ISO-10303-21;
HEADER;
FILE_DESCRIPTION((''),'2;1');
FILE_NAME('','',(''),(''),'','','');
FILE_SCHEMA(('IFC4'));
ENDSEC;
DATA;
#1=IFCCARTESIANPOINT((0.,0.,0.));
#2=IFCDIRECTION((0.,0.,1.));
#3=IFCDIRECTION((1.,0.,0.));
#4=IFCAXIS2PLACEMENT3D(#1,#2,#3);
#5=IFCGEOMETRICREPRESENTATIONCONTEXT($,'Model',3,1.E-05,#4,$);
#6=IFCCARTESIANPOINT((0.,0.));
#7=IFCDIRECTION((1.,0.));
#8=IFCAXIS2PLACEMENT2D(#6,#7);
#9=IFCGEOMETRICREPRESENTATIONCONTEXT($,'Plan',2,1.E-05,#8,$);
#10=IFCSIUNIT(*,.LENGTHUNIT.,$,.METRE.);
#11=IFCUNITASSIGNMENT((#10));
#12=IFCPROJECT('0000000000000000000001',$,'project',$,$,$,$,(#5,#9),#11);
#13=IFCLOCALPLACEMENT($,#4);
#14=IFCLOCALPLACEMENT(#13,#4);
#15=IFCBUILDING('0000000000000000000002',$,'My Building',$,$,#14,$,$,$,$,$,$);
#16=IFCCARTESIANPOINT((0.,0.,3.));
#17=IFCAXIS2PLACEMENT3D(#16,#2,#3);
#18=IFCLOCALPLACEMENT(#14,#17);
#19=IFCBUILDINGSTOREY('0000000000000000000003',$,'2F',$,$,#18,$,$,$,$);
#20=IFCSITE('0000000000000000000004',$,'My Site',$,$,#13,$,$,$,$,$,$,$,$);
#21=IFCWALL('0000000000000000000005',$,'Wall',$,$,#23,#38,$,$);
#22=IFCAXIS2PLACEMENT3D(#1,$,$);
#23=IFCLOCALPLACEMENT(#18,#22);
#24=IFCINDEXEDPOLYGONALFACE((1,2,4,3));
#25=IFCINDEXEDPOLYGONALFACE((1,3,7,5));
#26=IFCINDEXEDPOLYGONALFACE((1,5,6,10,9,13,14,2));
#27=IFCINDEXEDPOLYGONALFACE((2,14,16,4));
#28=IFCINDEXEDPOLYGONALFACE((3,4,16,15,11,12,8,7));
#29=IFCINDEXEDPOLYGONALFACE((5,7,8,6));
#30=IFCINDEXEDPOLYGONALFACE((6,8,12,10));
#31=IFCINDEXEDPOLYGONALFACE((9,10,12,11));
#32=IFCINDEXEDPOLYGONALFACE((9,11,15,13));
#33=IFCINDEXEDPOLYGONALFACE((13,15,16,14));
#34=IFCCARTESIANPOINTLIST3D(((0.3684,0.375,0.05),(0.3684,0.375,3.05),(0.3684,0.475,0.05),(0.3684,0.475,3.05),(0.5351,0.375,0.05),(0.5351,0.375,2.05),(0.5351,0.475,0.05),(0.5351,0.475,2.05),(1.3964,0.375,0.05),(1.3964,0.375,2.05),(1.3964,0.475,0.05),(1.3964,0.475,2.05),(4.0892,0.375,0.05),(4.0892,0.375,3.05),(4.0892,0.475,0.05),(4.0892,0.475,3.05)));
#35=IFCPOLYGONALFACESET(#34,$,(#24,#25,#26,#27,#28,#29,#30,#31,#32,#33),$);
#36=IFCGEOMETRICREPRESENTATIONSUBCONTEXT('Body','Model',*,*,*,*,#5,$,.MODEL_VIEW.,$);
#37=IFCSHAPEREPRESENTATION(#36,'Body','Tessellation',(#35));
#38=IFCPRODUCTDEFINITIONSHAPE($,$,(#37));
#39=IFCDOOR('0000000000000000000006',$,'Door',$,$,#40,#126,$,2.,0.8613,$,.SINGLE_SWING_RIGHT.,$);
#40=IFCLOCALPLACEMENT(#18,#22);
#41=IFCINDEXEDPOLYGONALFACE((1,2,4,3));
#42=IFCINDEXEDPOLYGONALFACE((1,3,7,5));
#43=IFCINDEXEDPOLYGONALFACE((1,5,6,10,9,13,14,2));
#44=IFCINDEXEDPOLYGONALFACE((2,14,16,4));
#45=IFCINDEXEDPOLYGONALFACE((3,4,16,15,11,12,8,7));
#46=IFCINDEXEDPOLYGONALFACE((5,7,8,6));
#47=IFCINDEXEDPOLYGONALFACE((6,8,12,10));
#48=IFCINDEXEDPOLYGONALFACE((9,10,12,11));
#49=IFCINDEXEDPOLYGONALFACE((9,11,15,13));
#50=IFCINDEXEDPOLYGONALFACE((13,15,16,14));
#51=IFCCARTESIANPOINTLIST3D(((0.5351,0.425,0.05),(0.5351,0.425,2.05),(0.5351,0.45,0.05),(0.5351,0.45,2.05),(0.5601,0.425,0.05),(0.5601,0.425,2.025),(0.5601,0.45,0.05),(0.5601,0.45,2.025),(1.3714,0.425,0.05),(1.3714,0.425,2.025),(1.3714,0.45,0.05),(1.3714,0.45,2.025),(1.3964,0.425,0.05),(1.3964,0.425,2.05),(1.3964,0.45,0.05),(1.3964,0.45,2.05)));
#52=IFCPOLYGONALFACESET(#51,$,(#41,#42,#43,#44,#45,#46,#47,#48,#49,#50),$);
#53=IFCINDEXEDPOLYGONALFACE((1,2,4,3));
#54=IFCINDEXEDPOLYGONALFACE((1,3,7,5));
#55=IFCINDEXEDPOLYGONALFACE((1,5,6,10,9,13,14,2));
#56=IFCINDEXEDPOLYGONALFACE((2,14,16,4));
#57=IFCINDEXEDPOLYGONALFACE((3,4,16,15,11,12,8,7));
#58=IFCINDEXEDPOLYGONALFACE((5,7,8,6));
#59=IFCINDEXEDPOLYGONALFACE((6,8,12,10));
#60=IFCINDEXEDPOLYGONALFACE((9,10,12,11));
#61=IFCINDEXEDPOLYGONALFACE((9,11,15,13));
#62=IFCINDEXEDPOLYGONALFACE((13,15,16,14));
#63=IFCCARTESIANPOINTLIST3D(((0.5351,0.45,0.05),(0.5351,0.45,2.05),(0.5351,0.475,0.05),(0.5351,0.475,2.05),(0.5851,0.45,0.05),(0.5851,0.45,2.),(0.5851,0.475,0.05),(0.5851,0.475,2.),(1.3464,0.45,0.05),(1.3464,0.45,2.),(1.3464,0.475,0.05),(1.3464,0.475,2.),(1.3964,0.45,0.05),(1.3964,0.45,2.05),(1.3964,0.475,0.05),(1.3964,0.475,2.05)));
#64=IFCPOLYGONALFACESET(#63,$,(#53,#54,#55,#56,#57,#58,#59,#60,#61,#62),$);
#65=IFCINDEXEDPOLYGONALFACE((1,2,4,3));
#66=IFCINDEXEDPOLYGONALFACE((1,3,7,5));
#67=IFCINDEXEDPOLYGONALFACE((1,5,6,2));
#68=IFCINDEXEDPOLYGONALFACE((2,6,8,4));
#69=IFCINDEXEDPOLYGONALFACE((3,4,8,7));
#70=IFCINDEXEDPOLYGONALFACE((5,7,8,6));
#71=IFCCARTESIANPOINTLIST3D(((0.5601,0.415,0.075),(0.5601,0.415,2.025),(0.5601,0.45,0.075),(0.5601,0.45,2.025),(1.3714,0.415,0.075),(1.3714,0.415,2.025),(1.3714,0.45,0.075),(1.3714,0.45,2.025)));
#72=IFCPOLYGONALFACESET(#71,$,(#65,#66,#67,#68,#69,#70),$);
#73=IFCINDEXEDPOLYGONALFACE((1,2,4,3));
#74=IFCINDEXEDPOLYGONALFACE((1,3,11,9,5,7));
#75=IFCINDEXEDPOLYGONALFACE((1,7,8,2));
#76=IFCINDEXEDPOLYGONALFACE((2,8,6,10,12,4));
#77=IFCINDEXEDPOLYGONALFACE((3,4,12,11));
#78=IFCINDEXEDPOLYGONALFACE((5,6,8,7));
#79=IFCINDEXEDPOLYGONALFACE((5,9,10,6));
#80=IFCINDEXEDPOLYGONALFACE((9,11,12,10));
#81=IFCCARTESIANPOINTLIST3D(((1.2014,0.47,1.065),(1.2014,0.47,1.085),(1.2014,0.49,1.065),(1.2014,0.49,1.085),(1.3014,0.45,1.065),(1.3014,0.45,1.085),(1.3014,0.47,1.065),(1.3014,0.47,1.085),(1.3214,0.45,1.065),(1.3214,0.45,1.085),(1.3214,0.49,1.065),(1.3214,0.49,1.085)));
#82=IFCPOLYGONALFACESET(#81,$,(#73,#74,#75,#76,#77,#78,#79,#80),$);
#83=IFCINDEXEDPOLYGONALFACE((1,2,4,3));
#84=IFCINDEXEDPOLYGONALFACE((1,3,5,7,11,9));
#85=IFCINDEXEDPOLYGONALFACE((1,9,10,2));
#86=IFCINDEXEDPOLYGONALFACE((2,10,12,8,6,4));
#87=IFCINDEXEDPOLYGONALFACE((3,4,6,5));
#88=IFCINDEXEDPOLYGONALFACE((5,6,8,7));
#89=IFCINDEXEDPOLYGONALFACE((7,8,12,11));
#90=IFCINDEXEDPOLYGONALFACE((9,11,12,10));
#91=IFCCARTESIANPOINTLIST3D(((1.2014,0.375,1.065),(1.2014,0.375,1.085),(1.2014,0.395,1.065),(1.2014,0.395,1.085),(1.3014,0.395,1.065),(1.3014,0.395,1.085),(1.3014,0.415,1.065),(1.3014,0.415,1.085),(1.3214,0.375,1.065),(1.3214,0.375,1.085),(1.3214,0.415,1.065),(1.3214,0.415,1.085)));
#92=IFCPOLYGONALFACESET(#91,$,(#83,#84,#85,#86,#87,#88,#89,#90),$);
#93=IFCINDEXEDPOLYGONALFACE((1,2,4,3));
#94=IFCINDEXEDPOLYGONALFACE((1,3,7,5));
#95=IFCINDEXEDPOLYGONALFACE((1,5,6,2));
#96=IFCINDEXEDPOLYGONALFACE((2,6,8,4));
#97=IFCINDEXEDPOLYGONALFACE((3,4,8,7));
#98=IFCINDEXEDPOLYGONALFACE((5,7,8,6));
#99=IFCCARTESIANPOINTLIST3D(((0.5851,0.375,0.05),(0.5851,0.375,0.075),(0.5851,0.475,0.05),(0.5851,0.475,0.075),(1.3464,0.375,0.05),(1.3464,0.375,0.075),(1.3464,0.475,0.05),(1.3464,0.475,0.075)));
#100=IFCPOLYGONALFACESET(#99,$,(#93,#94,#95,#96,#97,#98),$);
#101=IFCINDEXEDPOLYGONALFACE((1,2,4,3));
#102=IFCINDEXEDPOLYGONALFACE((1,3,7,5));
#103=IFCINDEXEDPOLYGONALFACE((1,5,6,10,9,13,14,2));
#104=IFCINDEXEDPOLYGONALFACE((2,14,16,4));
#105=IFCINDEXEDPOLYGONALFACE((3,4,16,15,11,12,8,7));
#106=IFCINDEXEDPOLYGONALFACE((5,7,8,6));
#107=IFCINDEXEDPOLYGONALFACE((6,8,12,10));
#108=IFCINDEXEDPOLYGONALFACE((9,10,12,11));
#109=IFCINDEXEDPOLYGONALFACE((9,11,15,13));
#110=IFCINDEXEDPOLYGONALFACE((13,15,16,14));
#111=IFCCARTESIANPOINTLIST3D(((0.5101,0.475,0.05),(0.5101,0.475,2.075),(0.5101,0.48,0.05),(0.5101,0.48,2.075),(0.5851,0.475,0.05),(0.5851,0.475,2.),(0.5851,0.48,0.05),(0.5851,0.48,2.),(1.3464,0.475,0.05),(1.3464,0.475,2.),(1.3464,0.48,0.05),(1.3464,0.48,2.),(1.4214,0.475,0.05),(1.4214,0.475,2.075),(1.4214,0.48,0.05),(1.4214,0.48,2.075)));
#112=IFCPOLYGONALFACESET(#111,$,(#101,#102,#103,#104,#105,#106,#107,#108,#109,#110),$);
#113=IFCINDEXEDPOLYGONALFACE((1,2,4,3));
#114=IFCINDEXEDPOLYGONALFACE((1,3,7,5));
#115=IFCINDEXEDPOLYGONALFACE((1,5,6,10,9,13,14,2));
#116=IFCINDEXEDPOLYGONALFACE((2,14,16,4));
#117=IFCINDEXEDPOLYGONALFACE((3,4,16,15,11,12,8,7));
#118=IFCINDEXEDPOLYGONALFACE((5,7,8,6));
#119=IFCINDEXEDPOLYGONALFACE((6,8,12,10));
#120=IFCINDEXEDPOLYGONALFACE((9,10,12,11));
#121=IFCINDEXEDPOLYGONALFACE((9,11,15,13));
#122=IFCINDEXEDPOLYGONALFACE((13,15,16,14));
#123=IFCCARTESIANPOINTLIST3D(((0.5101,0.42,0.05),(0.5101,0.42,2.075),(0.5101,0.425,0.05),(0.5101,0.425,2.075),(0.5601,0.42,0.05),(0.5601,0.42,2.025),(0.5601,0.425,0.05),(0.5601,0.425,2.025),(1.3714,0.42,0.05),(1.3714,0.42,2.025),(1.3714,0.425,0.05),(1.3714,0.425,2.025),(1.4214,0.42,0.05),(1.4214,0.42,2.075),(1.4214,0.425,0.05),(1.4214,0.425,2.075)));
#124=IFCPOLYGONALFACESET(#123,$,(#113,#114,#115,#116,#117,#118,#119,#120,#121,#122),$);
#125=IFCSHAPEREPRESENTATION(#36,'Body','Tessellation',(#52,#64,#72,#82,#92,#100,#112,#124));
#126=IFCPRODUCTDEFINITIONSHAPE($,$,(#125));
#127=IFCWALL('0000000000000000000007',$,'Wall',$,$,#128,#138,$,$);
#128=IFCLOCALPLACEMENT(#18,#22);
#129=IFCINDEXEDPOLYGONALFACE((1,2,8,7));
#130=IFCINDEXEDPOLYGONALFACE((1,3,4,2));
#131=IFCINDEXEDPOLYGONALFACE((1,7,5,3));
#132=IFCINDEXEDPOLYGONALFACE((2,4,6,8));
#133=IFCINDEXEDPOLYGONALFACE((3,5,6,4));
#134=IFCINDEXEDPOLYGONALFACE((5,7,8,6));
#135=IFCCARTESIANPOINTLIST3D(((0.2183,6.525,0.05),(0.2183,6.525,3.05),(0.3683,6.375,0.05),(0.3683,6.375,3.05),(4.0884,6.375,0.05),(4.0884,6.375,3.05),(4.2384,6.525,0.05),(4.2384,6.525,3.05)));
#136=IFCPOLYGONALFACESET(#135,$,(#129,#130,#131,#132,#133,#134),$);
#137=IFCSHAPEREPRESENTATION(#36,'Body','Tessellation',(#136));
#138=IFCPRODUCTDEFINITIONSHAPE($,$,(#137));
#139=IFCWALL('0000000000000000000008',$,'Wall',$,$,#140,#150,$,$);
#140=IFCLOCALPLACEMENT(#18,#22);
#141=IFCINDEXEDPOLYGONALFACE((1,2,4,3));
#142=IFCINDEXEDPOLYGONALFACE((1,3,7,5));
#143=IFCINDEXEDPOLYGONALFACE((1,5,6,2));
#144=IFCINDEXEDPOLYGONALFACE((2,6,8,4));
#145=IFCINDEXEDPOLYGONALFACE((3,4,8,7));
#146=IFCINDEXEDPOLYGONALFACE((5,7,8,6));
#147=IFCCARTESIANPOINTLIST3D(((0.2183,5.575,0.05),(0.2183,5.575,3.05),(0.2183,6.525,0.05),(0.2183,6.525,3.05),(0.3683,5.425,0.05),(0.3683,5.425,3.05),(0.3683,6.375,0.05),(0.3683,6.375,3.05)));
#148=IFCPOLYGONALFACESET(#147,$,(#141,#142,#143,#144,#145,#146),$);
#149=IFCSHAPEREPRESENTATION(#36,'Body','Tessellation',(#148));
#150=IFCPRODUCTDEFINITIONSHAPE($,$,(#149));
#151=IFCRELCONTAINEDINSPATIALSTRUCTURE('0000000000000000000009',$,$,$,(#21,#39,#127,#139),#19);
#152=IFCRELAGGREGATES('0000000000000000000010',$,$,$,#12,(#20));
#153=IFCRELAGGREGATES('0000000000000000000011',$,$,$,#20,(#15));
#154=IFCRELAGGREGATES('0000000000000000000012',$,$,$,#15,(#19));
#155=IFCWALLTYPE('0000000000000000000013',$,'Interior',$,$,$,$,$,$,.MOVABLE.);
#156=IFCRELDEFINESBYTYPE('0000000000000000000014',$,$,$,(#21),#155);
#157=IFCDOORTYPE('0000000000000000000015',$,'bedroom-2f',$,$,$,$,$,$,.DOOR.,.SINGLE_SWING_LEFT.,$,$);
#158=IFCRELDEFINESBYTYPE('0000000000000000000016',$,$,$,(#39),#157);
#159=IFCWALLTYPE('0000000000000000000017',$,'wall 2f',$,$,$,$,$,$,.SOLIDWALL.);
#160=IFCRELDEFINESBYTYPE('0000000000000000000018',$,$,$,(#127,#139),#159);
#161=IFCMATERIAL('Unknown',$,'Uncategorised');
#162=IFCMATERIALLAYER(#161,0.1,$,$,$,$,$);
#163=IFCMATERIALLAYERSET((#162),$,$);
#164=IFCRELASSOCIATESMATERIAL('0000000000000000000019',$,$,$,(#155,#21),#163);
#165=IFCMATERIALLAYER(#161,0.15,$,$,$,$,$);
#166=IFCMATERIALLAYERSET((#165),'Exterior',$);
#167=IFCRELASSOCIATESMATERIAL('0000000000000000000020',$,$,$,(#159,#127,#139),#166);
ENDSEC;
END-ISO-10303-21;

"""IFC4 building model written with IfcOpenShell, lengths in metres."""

from ifc_helpers import new_model, entity, si_unit, frame, origin_with_axes, origin_2d_with_axis, place, context, subcontext, project, spatial, line, indexed_curve, outline, extrude, shape, source, transform, mapped, material, layer, layer_set, layer_usage, type_object, type_shapes, element, fill, save


model = new_model("IFC4")

# Units and contexts
model_context = context("Model", 3, precision=1e-05, world=origin_with_axes())
plan_context = context("Plan", 2, precision=1e-05, world=origin_2d_with_axis())
body_context_1 = subcontext(model_context, "Body", "Model", "MODEL_VIEW")
body_context_2 = subcontext(plan_context, "Body", "Plan", "PLAN_VIEW")
ifc_project = project(units=[si_unit("LENGTHUNIT", "METRE")], contexts=[model_context, plan_context])

# Site, building, storey
site_placement = place(None, origin_with_axes())
site = spatial("IfcSite", under=ifc_project, at=site_placement, Name="My Site")
building_placement = place(site_placement, origin_with_axes())
building = spatial("IfcBuilding", under=site, at=building_placement, Name="My Building")
storey_placement = place(building_placement, frame((0.0, 0.0, 3.0), z_axis=(0.0, 0.0, 1.0), x_axis=(1.0, 0.0, 0.0)))
storey = spatial("IfcBuildingStorey", under=building, at=storey_placement, Name="2F")

# Shared definitions
ifc_material = material(Name="Unknown", Category="Uncategorised")

# Shared definitions
ifc_layer_1 = layer(ifc_material, 0.1)
ifc_layer_set_1 = layer_set([ifc_layer_1])
wall_type_1 = type_object("IfcWallType", Name="Interior", PredefinedType="MOVABLE", material=ifc_layer_set_1)
shared_shape_1 = source(origin_with_axes(), body_context_1, "Body", "SweptSolid", [
    extrude(outline(indexed_curve([(0.0, 0.0), (0.8613, 0.0), (0.8613, 2.0), (0.0, 2.0)], segments=[line(1, 2, 3, 4, 1)])), frame((0.0, -0.6, 0.0), z_axis=(0.0, -1.0, 0.0), x_axis=(1.0, 0.0, 0.0)), (0.0, 0.0, -1.0), 1.2),
])
door_type_1 = type_object("IfcDoorType", Name="bedroom-2f", OperationType="SINGLE_SWING_LEFT", PredefinedType="DOOR")
shared_shape_2 = source(origin_with_axes(), body_context_1, "Body", "SweptSolid", [
    extrude(outline(indexed_curve([(0.0, 0.0), (0.0, 2.0), (0.8613, 2.0), (0.8613, 0.0), (0.8363, 0.0), (0.8363, 1.975), (0.025, 1.975), (0.025, 0.0)], segments=[line(1, 2, 3, 4, 5, 6, 7, 8, 1)])), frame((0.0, 0.025, 0.0), z_axis=(0.0, -1.0, 0.0), x_axis=(1.0, 0.0, 0.0)), (0.0, 0.0, -1.0), 0.025),
    extrude(outline(indexed_curve([(0.0, 0.0), (0.0, 2.0), (0.8613, 2.0), (0.8613, 0.0), (0.8113, 0.0), (0.8113, 1.95), (0.05, 1.95), (0.05, 0.0)], segments=[line(1, 2, 3, 4, 5, 6, 7, 8, 1)])), frame((0.0, 0.0, 0.0), z_axis=(0.0, -1.0, 0.0), x_axis=(1.0, 0.0, 0.0)), (0.0, 0.0, -1.0), 0.025),
    extrude(outline(indexed_curve([(0.0, 0.0), (0.8113, 0.0), (0.8113, 0.035), (0.0, 0.035)], segments=[line(1, 2, 3, 4, 1)])), frame((0.025, 0.025, 0.025), z_axis=(0.0, 0.0, 1.0), x_axis=(1.0, 0.0, 0.0)), (0.0, 0.0, 1.0), 1.95),
    extrude(outline(indexed_curve([(0.0, 0.0), (0.0, -0.04), (0.12, -0.04), (0.12, -0.02), (0.02, -0.02), (0.02, 0.0)], segments=[line(1, 2, 3, 4, 5, 6, 1)])), frame((0.075, 0.025, 1.015), z_axis=(0.0, 0.0, 1.0), x_axis=(1.0, 0.0, 0.0)), (0.0, 0.0, 1.0), 0.02),
    extrude(outline(indexed_curve([(0.0, 0.0), (0.0, 0.04), (0.12, 0.04), (0.12, 0.02), (0.02, 0.02), (0.02, 0.0)], segments=[line(1, 2, 3, 4, 5, 6, 1)])), frame((0.075, 0.06, 1.015), z_axis=(0.0, 0.0, 1.0), x_axis=(1.0, 0.0, 0.0)), (0.0, 0.0, 1.0), 0.02),
    extrude(outline(indexed_curve([(0.0, 0.0), (0.7613, 0.0), (0.7613, 0.1), (0.0, 0.1)], segments=[line(1, 2, 3, 4, 1)])), frame((0.05, 0.0, 0.0), z_axis=(0.0, 0.0, 1.0), x_axis=(1.0, 0.0, 0.0)), (0.0, 0.0, 1.0), 0.025),
    extrude(outline(indexed_curve([(0.0, 0.0), (0.0, 2.025), (0.9113, 2.025), (0.9113, 0.0), (0.8363, 0.0), (0.8363, 1.95), (0.075, 1.95), (0.075, 0.0)], segments=[line(1, 2, 3, 4, 5, 6, 7, 8, 1)])), frame((-0.025, -0.005, 0.0), z_axis=(0.0, -1.0, 0.0), x_axis=(1.0, 0.0, 0.0)), (0.0, 0.0, -1.0), 0.005),
    extrude(outline(indexed_curve([(0.0, 0.0), (0.0, 2.025), (0.9113, 2.025), (0.9113, 0.0), (0.8613, 0.0), (0.8613, 1.975), (0.05, 1.975), (0.05, 0.0)], segments=[line(1, 2, 3, 4, 5, 6, 7, 8, 1)])), frame((-0.025, 0.05, 0.0), z_axis=(0.0, -1.0, 0.0), x_axis=(1.0, 0.0, 0.0)), (0.0, 0.0, -1.0), 0.005),
])
shared_shape_3 = source(origin_with_axes(), body_context_2, "Body", "Curve2D", [
    entity("IfcIndexedPolyCurve", entity("IfcCartesianPointList2D", [[0.0, 0.0], [0.0, 0.05], [0.025, 0.05], [0.025, 0.025], [0.05, 0.025], [0.05, 0.0]]), [entity("IfcLineIndex", [1, 2, 3, 4, 5, 6, 1])]),
    entity("IfcIndexedPolyCurve", entity("IfcCartesianPointList2D", [[0.8613, 0.0], [0.8613, 0.05], [0.8363, 0.05], [0.8363, 0.025], [0.8113, 0.025], [0.8113, 0.0]]), [entity("IfcLineIndex", [1, 2, 3, 4, 5, 6, 1])]),
    entity("IfcTrimmedCurve", entity("IfcEllipse", entity("IfcAxis2Placement2D", entity("IfcCartesianPoint", [0.8013, 0.05]), entity("IfcDirection", [1.0, 0.0])), 0.7763, 0.8113), [entity("IfcCartesianPoint", [0.8013, 0.8613])], [entity("IfcCartesianPoint", [0.025, 0.05])], True, "CARTESIAN"),
    entity("IfcIndexedPolyCurve", entity("IfcCartesianPointList2D", [[0.8363, 0.05], [0.8013, 0.05], [0.8013, 0.8613], [0.8363, 0.8613]]), [entity("IfcLineIndex", [1, 2, 3, 4, 1])]),
])
type_shapes(door_type_1, [shared_shape_2, shared_shape_3])

# Wall, opening, door
ifc_layer_usage_1 = layer_usage(ifc_layer_set_1, "AXIS2", "POSITIVE", 0.0)
wall_1_placement = place(storey_placement, frame((0.3684, 0.375, 0.05), z_axis=(0.0, 0.0, 1.0), x_axis=(1.0, 0.0, 0.0)))
wall_1 = element("IfcWall", 1, at=wall_1_placement, inside=storey, type_object=wall_type_1, material=ifc_layer_usage_1, Name="Wall", context=body_context_1, shape_type="SweptSolid", body=[
    extrude(outline(indexed_curve([(0.0, 0.0), (0.0, 0.1), (3.7209, 0.1), (3.7209, 0.0)], segments=[line(1, 2, 3, 4, 1)])), origin_with_axes(), (0.0, 0.0, 1.0), 3.0),
])
opening_1_placement = place(wall_1_placement, frame((1.028, 0.1, 0.0), z_axis=(0.0, 0.0, 1.0), x_axis=(-1.0, 0.0, 0.0)))
opening_1 = element("IfcOpeningElement", 2, at=opening_1_placement, cuts=wall_1, PredefinedType="OPENING", context=body_context_1, shape_type="MappedRepresentation", body=[
    mapped(shared_shape_1, transform((0.0, 0.0, 0.0), x_axis=(1.0, 0.0, 0.0), y_axis=(0.0, 1.0, 0.0), z_axis=(0.0, 0.0, 1.0), scale=1.0)),
])
door_1_placement = place(opening_1_placement, origin_with_axes())
door_1 = element("IfcDoor", 3, at=door_1_placement, inside=storey, type_object=door_type_1, Name="Door", OperationType="SINGLE_SWING_RIGHT", OverallHeight=2.0, OverallWidth=0.8613, shapes=[
    shape(body_context_1, "Body", "MappedRepresentation", [mapped(shared_shape_2, transform((0.0, 0.0, 0.0), x_axis=(1.0, 0.0, 0.0), y_axis=(0.0, 1.0, 0.0), z_axis=(0.0, 0.0, 1.0), scale=1.0))]),
    shape(body_context_2, "Body", "MappedRepresentation", [mapped(shared_shape_3, transform((0.0, 0.0, 0.0), x_axis=(1.0, 0.0, 0.0), y_axis=(0.0, 1.0, 0.0), z_axis=(0.0, 0.0, 1.0), scale=1.0))]),
])
fill(opening_1, door_1)

# Walls
ifc_layer_2 = layer(ifc_material, 0.15)
ifc_layer_set_2 = layer_set([ifc_layer_2], Name="Exterior")
ifc_layer_usage_2 = layer_usage(ifc_layer_set_2, "AXIS2", "POSITIVE", 0.0)
wall_type_2 = type_object("IfcWallType", Name="wall 2f", PredefinedType="SOLIDWALL", material=ifc_layer_set_2)
wall_2_placement = place(storey_placement, frame((4.2384, 6.525, 0.05), z_axis=(0.0, 0.0, 1.0), x_axis=(-1.0, 0.0, 0.0)))
element("IfcWall", 4, at=wall_2_placement, inside=storey, type_object=wall_type_2, material=ifc_layer_usage_2, Name="Wall", context=body_context_1, shape_type="SweptSolid", body=[
    extrude(outline(indexed_curve([(0.0, 0.0), (0.15, 0.15), (3.87, 0.15), (4.02, 0.0)], segments=[line(1, 2, 3, 4, 1)])), origin_with_axes(), (0.0, 0.0, 1.0), 3.0),
])
ifc_layer_usage_3 = layer_usage(ifc_layer_set_2, "AXIS2", "POSITIVE", 0.0)
wall_3_placement = place(storey_placement, frame((0.2183, 6.525, 0.05), z_axis=(0.0, 0.0, 1.0), x_axis=(0.0, -1.0, 0.0)))
element("IfcWall", 5, at=wall_3_placement, inside=storey, type_object=wall_type_2, material=ifc_layer_usage_3, Name="Wall", context=body_context_1, shape_type="SweptSolid", body=[
    extrude(outline(indexed_curve([(0.0, 0.0), (0.15, 0.15), (1.1, 0.15), (0.95, 0.0)], segments=[line(1, 2, 3, 4, 1)])), origin_with_axes(), (0.0, 0.0, 1.0), 3.0),
])

save(model, "model.ifc")
